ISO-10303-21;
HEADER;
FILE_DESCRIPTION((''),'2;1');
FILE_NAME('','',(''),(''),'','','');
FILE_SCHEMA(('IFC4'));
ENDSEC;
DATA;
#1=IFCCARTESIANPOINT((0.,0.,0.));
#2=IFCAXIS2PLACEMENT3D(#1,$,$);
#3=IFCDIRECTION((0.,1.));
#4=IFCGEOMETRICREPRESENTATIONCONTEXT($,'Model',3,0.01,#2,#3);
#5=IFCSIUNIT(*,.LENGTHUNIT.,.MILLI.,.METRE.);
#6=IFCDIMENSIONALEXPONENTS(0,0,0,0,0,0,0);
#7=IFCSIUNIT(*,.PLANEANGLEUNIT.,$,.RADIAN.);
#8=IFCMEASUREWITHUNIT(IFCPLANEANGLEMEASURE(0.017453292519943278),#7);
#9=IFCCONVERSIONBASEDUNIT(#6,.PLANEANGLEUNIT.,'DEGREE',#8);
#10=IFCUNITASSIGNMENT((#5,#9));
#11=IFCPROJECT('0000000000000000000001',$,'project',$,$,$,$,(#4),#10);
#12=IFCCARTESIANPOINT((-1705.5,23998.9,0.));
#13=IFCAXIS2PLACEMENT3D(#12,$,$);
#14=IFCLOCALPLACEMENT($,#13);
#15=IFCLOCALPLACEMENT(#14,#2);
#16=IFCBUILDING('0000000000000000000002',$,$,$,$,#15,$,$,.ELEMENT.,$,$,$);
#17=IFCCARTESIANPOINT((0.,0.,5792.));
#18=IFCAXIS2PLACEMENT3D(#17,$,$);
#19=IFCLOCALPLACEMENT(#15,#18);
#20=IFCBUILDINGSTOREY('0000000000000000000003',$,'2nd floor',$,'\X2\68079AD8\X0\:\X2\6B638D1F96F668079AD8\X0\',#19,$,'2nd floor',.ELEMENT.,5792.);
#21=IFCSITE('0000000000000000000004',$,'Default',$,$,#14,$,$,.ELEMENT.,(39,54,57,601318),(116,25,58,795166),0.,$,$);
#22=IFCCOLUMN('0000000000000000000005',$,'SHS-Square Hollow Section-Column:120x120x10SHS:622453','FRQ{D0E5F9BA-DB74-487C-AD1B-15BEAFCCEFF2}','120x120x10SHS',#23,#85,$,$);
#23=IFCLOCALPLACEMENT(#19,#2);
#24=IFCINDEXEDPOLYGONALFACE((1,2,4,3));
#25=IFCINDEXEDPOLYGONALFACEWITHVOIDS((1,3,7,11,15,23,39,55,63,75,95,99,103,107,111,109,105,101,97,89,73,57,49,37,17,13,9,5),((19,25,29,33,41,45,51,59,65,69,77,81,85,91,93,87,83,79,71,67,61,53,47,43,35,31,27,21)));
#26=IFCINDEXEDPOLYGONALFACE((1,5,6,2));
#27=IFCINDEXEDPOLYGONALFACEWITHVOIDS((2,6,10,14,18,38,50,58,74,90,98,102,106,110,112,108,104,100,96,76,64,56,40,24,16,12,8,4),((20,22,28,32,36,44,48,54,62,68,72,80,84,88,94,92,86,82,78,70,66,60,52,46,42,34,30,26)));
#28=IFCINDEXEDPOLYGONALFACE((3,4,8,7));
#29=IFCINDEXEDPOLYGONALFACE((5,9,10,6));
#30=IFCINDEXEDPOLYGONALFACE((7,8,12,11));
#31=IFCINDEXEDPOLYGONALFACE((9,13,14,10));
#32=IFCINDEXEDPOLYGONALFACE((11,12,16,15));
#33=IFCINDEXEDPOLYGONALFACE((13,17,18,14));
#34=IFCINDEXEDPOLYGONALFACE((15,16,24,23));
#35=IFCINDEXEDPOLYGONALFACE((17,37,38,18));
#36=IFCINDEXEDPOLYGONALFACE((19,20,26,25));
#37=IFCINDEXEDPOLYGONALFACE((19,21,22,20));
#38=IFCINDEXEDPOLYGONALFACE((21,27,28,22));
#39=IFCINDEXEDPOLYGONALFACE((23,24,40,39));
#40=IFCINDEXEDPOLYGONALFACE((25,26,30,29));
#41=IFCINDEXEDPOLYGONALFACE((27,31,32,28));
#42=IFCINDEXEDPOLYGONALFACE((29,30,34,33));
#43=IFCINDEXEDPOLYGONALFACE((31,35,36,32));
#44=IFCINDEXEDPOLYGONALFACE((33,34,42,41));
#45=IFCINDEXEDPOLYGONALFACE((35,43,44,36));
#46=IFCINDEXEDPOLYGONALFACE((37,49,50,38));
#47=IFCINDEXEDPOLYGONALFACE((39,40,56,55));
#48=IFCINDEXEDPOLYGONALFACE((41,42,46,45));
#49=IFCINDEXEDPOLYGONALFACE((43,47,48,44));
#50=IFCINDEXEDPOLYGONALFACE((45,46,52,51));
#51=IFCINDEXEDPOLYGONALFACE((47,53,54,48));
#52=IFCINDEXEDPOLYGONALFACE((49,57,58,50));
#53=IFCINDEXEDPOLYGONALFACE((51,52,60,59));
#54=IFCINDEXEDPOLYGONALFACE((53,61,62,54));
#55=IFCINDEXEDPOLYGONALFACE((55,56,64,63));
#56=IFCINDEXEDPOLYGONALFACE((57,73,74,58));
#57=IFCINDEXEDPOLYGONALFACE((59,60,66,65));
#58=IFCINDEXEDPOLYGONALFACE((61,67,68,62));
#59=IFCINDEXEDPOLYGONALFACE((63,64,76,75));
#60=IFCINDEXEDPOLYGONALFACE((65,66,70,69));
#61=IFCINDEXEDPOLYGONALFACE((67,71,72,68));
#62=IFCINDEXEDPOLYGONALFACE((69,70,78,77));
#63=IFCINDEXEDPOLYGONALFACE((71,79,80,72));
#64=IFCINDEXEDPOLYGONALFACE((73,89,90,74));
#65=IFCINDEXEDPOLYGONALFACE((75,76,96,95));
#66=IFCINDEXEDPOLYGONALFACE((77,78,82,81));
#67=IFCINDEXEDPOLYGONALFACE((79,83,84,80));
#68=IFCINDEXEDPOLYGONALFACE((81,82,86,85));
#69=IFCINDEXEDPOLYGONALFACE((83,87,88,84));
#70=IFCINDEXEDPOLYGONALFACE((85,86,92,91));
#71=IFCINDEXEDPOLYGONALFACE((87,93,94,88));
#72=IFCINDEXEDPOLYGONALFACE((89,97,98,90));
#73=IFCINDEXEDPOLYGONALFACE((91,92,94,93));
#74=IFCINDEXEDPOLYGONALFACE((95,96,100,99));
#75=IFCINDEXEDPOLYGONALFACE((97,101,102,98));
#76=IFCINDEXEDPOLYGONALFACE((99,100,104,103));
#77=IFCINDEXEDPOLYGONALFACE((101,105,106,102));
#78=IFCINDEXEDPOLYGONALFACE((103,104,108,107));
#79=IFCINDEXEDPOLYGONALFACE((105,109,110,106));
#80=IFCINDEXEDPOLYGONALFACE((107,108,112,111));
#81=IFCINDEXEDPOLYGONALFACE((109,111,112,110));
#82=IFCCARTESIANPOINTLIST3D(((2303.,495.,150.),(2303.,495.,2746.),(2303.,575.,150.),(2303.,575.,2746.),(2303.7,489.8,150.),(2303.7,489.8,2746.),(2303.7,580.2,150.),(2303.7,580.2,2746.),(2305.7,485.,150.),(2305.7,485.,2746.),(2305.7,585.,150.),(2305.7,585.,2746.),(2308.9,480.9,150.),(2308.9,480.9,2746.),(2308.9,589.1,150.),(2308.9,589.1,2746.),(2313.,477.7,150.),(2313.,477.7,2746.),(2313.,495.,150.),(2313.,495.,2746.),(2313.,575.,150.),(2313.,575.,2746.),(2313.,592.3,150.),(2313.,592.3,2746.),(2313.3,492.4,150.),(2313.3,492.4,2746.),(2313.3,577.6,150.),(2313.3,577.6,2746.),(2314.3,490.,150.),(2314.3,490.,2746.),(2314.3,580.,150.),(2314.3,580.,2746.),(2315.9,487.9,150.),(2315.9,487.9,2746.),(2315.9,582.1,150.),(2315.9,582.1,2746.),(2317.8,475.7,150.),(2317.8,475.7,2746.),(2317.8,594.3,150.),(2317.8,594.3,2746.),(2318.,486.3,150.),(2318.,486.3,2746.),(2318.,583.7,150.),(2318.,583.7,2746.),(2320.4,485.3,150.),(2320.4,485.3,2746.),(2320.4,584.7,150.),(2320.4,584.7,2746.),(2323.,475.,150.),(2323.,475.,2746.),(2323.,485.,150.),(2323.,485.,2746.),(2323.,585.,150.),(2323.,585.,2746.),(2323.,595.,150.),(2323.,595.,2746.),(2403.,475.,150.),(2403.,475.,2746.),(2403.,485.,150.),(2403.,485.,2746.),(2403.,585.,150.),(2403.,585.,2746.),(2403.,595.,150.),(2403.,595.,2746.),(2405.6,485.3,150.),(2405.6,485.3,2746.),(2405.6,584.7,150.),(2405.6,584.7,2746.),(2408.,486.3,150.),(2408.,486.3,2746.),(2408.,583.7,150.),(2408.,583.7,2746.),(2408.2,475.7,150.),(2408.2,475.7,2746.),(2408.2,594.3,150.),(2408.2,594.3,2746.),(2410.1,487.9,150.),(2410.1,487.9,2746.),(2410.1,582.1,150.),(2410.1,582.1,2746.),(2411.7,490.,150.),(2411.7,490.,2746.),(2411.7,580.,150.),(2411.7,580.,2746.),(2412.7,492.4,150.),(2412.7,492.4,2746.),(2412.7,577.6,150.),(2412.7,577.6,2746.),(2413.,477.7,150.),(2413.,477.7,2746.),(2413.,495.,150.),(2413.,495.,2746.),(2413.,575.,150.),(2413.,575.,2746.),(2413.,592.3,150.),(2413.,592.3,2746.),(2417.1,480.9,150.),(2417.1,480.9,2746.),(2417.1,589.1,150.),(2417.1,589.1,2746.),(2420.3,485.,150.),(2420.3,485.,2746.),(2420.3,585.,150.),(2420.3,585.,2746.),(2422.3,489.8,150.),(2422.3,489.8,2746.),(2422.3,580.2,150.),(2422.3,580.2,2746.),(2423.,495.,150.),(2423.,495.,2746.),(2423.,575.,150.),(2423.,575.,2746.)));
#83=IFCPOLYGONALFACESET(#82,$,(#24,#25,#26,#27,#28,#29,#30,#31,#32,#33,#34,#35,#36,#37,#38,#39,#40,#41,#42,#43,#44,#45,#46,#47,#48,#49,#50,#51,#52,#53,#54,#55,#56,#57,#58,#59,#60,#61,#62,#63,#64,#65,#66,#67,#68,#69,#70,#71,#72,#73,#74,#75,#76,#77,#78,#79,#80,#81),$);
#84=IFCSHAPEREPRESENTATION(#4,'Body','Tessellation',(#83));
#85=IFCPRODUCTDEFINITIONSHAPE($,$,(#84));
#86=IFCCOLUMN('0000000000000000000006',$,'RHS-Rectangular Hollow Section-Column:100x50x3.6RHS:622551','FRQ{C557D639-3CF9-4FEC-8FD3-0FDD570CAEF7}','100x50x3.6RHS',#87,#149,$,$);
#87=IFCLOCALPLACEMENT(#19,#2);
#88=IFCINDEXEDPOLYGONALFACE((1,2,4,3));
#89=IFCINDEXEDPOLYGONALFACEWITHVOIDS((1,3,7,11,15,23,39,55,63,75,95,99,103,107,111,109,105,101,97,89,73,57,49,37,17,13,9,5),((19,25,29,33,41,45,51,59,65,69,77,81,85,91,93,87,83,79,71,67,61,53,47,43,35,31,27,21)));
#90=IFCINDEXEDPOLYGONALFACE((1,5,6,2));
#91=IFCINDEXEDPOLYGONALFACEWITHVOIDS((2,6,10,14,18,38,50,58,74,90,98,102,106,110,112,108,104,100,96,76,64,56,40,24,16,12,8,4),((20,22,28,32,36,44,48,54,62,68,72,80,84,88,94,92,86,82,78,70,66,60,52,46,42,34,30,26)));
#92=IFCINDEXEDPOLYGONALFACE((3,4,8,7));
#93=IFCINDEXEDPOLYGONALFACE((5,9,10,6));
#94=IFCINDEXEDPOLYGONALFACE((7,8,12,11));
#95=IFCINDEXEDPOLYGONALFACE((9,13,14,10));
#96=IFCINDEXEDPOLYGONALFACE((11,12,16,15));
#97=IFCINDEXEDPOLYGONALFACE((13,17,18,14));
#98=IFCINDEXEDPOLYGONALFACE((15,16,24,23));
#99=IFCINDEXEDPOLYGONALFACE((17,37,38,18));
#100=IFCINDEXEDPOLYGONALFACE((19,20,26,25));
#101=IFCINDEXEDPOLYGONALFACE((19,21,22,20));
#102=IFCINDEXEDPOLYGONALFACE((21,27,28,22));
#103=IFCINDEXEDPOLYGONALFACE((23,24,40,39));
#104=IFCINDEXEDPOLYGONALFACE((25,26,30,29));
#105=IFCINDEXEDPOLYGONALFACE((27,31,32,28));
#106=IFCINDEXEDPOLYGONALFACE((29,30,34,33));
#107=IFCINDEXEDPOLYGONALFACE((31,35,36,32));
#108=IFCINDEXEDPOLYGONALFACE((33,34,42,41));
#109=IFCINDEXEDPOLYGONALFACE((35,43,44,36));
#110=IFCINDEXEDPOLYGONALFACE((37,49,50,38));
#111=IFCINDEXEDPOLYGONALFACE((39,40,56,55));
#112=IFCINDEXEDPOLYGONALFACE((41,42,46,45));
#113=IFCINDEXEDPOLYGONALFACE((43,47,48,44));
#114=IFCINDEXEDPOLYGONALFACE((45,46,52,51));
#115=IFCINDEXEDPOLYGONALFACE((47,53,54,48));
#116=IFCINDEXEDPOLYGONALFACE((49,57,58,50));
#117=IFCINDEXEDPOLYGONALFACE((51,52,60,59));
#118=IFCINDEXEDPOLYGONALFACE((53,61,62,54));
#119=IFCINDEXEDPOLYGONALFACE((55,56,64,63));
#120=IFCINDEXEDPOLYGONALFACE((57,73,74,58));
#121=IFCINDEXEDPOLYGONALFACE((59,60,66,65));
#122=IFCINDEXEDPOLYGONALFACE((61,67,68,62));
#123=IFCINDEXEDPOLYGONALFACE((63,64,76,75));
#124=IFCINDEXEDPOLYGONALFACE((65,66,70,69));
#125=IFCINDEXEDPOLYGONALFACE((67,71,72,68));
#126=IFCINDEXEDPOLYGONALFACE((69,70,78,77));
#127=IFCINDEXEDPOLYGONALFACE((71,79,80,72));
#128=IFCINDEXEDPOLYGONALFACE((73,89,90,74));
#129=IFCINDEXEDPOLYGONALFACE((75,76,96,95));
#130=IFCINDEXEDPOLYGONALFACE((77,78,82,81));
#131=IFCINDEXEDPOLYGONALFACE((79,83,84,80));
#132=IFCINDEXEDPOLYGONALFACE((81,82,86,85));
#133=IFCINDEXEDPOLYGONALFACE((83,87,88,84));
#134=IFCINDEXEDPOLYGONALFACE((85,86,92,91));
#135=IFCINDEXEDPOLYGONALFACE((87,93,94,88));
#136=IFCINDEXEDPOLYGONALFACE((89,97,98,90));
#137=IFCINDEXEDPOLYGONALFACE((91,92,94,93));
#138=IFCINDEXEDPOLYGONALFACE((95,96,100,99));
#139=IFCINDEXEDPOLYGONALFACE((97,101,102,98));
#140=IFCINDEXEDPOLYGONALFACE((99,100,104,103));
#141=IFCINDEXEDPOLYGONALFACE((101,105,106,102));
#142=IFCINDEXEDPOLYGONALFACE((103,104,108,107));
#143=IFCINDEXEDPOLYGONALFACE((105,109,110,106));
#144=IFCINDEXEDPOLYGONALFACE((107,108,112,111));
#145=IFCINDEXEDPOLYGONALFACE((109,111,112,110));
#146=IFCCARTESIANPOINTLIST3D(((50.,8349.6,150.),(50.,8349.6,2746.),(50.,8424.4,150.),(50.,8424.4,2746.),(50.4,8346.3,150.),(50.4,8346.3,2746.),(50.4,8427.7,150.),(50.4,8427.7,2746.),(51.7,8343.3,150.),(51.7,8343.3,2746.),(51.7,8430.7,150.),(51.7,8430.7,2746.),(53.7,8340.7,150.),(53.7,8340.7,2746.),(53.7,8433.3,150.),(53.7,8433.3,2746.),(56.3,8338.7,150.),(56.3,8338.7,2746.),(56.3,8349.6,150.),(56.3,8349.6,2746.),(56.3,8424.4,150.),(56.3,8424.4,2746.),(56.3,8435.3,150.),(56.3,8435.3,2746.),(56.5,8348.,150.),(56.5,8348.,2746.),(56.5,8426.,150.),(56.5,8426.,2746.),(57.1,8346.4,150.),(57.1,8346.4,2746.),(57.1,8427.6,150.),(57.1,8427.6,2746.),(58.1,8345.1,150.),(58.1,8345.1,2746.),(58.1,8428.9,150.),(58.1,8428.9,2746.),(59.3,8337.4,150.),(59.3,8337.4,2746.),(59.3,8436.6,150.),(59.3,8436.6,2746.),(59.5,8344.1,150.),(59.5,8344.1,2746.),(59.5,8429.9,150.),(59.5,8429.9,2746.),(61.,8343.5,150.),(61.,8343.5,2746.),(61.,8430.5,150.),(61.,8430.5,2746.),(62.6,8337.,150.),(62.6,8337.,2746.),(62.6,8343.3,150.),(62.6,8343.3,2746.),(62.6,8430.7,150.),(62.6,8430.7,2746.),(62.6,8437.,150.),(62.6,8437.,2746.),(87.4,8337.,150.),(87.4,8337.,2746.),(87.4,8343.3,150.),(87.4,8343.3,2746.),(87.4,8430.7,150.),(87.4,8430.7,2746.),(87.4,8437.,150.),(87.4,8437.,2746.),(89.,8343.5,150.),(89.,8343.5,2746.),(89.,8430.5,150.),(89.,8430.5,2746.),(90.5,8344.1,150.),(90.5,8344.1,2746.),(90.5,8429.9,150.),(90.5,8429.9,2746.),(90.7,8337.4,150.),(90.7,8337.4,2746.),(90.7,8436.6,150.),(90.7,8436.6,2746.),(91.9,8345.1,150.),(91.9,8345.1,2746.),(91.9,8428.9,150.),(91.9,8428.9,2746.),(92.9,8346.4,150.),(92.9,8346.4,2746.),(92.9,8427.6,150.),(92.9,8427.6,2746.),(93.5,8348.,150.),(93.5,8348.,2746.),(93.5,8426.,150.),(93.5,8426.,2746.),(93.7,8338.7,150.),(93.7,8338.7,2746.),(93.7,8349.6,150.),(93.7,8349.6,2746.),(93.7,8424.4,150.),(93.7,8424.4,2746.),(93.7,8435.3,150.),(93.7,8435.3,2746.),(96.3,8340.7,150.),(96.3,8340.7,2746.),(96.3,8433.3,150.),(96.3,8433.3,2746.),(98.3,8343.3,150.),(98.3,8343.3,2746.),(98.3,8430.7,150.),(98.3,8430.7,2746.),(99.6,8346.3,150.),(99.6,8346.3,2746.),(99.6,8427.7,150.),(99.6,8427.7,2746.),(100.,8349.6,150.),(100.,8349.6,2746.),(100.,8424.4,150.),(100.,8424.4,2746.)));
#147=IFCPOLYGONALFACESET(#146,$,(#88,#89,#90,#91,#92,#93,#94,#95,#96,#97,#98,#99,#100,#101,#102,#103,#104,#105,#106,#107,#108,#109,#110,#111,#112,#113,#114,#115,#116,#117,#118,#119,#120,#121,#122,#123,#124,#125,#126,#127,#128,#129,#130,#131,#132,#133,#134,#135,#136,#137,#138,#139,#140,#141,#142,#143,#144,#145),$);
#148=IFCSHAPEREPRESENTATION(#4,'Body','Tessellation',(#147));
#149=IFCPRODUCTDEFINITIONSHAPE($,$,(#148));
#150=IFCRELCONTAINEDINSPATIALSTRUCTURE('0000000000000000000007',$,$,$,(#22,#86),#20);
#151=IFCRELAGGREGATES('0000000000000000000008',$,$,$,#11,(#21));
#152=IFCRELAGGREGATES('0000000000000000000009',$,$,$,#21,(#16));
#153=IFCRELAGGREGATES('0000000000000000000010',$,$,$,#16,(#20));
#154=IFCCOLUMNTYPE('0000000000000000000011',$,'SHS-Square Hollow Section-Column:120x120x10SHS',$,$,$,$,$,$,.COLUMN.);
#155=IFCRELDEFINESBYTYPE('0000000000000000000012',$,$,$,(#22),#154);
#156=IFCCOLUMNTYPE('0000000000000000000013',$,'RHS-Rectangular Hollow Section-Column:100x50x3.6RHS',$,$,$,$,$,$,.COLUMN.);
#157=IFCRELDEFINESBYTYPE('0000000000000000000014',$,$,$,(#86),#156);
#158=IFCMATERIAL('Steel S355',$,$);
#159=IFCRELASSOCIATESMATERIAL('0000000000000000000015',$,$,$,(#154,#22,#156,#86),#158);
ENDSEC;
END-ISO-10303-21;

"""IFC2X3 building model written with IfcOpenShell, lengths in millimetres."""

from ifc_helpers import new_model, entity, si_unit, converted_unit, direction, frame, origin, origin_2d, place, context, project, spatial, hollow_rectangle, extrude, clip, halfspace, material, type_object, element, save


model = new_model("IFC2X3")

# Units and contexts
model_context = context("Model", 3, precision=0.01, world=origin(), true_north=direction((0.0, 1.0)))
ifc_project = project(units=[si_unit("LENGTHUNIT", "METRE", prefix="MILLI"), converted_unit("PLANEANGLEUNIT", "DEGREE", entity("IfcPlaneAngleMeasure", 0.017453292519943278), si_unit("PLANEANGLEUNIT", "RADIAN"), dimensions=[0, 0, 0, 0, 0, 0, 0])], contexts=[model_context])

# Site, building, storey
site_placement = place(None, frame((-1705.5, 23998.9, 0.0)))
site = spatial("IfcSite", under=ifc_project, at=site_placement, Name="Default", CompositionType="ELEMENT", RefLatitude=(39, 54, 57, 601318), RefLongitude=(116, 25, 58, 795166), RefElevation=0.0)
building_placement = place(site_placement, origin())
building = spatial("IfcBuilding", under=site, at=building_placement, CompositionType="ELEMENT")
storey_placement = place(building_placement, frame((0.0, 0.0, 5792.0)))
storey = spatial("IfcBuildingStorey", under=building, at=storey_placement, Name="2nd floor", ObjectType="标高:正负零标高", LongName="2nd floor", CompositionType="ELEMENT", Elevation=5792.0)

# Columns
ifc_material_1 = material(Name="Steel S355")
column_type_1 = type_object("IfcColumnType", Name="SHS-Square Hollow Section-Column:120x120x10SHS", PredefinedType="COLUMN", material=ifc_material_1)
column_1_placement = place(storey_placement, frame((2363.0, 535.0, 2746.0), z_axis=(0.0, 0.0, 1.0), x_axis=(0.0, -1.0, 0.0)))
element("IfcColumn", 1, at=column_1_placement, inside=storey, type_object=column_type_1, material=ifc_material_1, Name="SHS-Square Hollow Section-Column:120x120x10SHS:622453", Description="FRQ{D0E5F9BA-DB74-487C-AD1B-15BEAFCCEFF2}", ObjectType="120x120x10SHS", context=model_context, shape_type="Clipping", body=[
    clip(extrude(hollow_rectangle(XDim=120.0, YDim=120.0, WallThickness=10.0, InnerFilletRadius=10.0, OuterFilletRadius=20.0, at=origin_2d()), origin(), (0.0, 0.0, -1.0), 2680.9), halfspace(frame((535.0, -2363.0, -2596.0), z_axis=(0.0, 0.0, 1.0), x_axis=(0.0, 1.0, 0.0)), True)),
])
column_type_2 = type_object("IfcColumnType", Name="RHS-Rectangular Hollow Section-Column:100x50x3.6RHS", PredefinedType="COLUMN", material=ifc_material_1)
column_2_placement = place(storey_placement, frame((75.0, 8387.0, 2746.0), z_axis=(0.0, 0.0, 1.0), x_axis=(-1.0, 0.0, 0.0)))
element("IfcColumn", 2, at=column_2_placement, inside=storey, type_object=column_type_2, material=ifc_material_1, Name="RHS-Rectangular Hollow Section-Column:100x50x3.6RHS:622551", Description="FRQ{C557D639-3CF9-4FEC-8FD3-0FDD570CAEF7}", ObjectType="100x50x3.6RHS", context=model_context, shape_type="Clipping", body=[
    clip(extrude(hollow_rectangle(XDim=50.0, YDim=100.0, WallThickness=6.3, InnerFilletRadius=6.3, OuterFilletRadius=12.6, at=origin_2d()), origin(), (0.0, 0.0, -1.0), 2651.9), halfspace(frame((75.0, 8387.0, -2596.0), z_axis=(0.0, 0.0, 1.0), x_axis=(-1.0, 0.0, 0.0)), True)),
])

save(model, "model.ifc")
